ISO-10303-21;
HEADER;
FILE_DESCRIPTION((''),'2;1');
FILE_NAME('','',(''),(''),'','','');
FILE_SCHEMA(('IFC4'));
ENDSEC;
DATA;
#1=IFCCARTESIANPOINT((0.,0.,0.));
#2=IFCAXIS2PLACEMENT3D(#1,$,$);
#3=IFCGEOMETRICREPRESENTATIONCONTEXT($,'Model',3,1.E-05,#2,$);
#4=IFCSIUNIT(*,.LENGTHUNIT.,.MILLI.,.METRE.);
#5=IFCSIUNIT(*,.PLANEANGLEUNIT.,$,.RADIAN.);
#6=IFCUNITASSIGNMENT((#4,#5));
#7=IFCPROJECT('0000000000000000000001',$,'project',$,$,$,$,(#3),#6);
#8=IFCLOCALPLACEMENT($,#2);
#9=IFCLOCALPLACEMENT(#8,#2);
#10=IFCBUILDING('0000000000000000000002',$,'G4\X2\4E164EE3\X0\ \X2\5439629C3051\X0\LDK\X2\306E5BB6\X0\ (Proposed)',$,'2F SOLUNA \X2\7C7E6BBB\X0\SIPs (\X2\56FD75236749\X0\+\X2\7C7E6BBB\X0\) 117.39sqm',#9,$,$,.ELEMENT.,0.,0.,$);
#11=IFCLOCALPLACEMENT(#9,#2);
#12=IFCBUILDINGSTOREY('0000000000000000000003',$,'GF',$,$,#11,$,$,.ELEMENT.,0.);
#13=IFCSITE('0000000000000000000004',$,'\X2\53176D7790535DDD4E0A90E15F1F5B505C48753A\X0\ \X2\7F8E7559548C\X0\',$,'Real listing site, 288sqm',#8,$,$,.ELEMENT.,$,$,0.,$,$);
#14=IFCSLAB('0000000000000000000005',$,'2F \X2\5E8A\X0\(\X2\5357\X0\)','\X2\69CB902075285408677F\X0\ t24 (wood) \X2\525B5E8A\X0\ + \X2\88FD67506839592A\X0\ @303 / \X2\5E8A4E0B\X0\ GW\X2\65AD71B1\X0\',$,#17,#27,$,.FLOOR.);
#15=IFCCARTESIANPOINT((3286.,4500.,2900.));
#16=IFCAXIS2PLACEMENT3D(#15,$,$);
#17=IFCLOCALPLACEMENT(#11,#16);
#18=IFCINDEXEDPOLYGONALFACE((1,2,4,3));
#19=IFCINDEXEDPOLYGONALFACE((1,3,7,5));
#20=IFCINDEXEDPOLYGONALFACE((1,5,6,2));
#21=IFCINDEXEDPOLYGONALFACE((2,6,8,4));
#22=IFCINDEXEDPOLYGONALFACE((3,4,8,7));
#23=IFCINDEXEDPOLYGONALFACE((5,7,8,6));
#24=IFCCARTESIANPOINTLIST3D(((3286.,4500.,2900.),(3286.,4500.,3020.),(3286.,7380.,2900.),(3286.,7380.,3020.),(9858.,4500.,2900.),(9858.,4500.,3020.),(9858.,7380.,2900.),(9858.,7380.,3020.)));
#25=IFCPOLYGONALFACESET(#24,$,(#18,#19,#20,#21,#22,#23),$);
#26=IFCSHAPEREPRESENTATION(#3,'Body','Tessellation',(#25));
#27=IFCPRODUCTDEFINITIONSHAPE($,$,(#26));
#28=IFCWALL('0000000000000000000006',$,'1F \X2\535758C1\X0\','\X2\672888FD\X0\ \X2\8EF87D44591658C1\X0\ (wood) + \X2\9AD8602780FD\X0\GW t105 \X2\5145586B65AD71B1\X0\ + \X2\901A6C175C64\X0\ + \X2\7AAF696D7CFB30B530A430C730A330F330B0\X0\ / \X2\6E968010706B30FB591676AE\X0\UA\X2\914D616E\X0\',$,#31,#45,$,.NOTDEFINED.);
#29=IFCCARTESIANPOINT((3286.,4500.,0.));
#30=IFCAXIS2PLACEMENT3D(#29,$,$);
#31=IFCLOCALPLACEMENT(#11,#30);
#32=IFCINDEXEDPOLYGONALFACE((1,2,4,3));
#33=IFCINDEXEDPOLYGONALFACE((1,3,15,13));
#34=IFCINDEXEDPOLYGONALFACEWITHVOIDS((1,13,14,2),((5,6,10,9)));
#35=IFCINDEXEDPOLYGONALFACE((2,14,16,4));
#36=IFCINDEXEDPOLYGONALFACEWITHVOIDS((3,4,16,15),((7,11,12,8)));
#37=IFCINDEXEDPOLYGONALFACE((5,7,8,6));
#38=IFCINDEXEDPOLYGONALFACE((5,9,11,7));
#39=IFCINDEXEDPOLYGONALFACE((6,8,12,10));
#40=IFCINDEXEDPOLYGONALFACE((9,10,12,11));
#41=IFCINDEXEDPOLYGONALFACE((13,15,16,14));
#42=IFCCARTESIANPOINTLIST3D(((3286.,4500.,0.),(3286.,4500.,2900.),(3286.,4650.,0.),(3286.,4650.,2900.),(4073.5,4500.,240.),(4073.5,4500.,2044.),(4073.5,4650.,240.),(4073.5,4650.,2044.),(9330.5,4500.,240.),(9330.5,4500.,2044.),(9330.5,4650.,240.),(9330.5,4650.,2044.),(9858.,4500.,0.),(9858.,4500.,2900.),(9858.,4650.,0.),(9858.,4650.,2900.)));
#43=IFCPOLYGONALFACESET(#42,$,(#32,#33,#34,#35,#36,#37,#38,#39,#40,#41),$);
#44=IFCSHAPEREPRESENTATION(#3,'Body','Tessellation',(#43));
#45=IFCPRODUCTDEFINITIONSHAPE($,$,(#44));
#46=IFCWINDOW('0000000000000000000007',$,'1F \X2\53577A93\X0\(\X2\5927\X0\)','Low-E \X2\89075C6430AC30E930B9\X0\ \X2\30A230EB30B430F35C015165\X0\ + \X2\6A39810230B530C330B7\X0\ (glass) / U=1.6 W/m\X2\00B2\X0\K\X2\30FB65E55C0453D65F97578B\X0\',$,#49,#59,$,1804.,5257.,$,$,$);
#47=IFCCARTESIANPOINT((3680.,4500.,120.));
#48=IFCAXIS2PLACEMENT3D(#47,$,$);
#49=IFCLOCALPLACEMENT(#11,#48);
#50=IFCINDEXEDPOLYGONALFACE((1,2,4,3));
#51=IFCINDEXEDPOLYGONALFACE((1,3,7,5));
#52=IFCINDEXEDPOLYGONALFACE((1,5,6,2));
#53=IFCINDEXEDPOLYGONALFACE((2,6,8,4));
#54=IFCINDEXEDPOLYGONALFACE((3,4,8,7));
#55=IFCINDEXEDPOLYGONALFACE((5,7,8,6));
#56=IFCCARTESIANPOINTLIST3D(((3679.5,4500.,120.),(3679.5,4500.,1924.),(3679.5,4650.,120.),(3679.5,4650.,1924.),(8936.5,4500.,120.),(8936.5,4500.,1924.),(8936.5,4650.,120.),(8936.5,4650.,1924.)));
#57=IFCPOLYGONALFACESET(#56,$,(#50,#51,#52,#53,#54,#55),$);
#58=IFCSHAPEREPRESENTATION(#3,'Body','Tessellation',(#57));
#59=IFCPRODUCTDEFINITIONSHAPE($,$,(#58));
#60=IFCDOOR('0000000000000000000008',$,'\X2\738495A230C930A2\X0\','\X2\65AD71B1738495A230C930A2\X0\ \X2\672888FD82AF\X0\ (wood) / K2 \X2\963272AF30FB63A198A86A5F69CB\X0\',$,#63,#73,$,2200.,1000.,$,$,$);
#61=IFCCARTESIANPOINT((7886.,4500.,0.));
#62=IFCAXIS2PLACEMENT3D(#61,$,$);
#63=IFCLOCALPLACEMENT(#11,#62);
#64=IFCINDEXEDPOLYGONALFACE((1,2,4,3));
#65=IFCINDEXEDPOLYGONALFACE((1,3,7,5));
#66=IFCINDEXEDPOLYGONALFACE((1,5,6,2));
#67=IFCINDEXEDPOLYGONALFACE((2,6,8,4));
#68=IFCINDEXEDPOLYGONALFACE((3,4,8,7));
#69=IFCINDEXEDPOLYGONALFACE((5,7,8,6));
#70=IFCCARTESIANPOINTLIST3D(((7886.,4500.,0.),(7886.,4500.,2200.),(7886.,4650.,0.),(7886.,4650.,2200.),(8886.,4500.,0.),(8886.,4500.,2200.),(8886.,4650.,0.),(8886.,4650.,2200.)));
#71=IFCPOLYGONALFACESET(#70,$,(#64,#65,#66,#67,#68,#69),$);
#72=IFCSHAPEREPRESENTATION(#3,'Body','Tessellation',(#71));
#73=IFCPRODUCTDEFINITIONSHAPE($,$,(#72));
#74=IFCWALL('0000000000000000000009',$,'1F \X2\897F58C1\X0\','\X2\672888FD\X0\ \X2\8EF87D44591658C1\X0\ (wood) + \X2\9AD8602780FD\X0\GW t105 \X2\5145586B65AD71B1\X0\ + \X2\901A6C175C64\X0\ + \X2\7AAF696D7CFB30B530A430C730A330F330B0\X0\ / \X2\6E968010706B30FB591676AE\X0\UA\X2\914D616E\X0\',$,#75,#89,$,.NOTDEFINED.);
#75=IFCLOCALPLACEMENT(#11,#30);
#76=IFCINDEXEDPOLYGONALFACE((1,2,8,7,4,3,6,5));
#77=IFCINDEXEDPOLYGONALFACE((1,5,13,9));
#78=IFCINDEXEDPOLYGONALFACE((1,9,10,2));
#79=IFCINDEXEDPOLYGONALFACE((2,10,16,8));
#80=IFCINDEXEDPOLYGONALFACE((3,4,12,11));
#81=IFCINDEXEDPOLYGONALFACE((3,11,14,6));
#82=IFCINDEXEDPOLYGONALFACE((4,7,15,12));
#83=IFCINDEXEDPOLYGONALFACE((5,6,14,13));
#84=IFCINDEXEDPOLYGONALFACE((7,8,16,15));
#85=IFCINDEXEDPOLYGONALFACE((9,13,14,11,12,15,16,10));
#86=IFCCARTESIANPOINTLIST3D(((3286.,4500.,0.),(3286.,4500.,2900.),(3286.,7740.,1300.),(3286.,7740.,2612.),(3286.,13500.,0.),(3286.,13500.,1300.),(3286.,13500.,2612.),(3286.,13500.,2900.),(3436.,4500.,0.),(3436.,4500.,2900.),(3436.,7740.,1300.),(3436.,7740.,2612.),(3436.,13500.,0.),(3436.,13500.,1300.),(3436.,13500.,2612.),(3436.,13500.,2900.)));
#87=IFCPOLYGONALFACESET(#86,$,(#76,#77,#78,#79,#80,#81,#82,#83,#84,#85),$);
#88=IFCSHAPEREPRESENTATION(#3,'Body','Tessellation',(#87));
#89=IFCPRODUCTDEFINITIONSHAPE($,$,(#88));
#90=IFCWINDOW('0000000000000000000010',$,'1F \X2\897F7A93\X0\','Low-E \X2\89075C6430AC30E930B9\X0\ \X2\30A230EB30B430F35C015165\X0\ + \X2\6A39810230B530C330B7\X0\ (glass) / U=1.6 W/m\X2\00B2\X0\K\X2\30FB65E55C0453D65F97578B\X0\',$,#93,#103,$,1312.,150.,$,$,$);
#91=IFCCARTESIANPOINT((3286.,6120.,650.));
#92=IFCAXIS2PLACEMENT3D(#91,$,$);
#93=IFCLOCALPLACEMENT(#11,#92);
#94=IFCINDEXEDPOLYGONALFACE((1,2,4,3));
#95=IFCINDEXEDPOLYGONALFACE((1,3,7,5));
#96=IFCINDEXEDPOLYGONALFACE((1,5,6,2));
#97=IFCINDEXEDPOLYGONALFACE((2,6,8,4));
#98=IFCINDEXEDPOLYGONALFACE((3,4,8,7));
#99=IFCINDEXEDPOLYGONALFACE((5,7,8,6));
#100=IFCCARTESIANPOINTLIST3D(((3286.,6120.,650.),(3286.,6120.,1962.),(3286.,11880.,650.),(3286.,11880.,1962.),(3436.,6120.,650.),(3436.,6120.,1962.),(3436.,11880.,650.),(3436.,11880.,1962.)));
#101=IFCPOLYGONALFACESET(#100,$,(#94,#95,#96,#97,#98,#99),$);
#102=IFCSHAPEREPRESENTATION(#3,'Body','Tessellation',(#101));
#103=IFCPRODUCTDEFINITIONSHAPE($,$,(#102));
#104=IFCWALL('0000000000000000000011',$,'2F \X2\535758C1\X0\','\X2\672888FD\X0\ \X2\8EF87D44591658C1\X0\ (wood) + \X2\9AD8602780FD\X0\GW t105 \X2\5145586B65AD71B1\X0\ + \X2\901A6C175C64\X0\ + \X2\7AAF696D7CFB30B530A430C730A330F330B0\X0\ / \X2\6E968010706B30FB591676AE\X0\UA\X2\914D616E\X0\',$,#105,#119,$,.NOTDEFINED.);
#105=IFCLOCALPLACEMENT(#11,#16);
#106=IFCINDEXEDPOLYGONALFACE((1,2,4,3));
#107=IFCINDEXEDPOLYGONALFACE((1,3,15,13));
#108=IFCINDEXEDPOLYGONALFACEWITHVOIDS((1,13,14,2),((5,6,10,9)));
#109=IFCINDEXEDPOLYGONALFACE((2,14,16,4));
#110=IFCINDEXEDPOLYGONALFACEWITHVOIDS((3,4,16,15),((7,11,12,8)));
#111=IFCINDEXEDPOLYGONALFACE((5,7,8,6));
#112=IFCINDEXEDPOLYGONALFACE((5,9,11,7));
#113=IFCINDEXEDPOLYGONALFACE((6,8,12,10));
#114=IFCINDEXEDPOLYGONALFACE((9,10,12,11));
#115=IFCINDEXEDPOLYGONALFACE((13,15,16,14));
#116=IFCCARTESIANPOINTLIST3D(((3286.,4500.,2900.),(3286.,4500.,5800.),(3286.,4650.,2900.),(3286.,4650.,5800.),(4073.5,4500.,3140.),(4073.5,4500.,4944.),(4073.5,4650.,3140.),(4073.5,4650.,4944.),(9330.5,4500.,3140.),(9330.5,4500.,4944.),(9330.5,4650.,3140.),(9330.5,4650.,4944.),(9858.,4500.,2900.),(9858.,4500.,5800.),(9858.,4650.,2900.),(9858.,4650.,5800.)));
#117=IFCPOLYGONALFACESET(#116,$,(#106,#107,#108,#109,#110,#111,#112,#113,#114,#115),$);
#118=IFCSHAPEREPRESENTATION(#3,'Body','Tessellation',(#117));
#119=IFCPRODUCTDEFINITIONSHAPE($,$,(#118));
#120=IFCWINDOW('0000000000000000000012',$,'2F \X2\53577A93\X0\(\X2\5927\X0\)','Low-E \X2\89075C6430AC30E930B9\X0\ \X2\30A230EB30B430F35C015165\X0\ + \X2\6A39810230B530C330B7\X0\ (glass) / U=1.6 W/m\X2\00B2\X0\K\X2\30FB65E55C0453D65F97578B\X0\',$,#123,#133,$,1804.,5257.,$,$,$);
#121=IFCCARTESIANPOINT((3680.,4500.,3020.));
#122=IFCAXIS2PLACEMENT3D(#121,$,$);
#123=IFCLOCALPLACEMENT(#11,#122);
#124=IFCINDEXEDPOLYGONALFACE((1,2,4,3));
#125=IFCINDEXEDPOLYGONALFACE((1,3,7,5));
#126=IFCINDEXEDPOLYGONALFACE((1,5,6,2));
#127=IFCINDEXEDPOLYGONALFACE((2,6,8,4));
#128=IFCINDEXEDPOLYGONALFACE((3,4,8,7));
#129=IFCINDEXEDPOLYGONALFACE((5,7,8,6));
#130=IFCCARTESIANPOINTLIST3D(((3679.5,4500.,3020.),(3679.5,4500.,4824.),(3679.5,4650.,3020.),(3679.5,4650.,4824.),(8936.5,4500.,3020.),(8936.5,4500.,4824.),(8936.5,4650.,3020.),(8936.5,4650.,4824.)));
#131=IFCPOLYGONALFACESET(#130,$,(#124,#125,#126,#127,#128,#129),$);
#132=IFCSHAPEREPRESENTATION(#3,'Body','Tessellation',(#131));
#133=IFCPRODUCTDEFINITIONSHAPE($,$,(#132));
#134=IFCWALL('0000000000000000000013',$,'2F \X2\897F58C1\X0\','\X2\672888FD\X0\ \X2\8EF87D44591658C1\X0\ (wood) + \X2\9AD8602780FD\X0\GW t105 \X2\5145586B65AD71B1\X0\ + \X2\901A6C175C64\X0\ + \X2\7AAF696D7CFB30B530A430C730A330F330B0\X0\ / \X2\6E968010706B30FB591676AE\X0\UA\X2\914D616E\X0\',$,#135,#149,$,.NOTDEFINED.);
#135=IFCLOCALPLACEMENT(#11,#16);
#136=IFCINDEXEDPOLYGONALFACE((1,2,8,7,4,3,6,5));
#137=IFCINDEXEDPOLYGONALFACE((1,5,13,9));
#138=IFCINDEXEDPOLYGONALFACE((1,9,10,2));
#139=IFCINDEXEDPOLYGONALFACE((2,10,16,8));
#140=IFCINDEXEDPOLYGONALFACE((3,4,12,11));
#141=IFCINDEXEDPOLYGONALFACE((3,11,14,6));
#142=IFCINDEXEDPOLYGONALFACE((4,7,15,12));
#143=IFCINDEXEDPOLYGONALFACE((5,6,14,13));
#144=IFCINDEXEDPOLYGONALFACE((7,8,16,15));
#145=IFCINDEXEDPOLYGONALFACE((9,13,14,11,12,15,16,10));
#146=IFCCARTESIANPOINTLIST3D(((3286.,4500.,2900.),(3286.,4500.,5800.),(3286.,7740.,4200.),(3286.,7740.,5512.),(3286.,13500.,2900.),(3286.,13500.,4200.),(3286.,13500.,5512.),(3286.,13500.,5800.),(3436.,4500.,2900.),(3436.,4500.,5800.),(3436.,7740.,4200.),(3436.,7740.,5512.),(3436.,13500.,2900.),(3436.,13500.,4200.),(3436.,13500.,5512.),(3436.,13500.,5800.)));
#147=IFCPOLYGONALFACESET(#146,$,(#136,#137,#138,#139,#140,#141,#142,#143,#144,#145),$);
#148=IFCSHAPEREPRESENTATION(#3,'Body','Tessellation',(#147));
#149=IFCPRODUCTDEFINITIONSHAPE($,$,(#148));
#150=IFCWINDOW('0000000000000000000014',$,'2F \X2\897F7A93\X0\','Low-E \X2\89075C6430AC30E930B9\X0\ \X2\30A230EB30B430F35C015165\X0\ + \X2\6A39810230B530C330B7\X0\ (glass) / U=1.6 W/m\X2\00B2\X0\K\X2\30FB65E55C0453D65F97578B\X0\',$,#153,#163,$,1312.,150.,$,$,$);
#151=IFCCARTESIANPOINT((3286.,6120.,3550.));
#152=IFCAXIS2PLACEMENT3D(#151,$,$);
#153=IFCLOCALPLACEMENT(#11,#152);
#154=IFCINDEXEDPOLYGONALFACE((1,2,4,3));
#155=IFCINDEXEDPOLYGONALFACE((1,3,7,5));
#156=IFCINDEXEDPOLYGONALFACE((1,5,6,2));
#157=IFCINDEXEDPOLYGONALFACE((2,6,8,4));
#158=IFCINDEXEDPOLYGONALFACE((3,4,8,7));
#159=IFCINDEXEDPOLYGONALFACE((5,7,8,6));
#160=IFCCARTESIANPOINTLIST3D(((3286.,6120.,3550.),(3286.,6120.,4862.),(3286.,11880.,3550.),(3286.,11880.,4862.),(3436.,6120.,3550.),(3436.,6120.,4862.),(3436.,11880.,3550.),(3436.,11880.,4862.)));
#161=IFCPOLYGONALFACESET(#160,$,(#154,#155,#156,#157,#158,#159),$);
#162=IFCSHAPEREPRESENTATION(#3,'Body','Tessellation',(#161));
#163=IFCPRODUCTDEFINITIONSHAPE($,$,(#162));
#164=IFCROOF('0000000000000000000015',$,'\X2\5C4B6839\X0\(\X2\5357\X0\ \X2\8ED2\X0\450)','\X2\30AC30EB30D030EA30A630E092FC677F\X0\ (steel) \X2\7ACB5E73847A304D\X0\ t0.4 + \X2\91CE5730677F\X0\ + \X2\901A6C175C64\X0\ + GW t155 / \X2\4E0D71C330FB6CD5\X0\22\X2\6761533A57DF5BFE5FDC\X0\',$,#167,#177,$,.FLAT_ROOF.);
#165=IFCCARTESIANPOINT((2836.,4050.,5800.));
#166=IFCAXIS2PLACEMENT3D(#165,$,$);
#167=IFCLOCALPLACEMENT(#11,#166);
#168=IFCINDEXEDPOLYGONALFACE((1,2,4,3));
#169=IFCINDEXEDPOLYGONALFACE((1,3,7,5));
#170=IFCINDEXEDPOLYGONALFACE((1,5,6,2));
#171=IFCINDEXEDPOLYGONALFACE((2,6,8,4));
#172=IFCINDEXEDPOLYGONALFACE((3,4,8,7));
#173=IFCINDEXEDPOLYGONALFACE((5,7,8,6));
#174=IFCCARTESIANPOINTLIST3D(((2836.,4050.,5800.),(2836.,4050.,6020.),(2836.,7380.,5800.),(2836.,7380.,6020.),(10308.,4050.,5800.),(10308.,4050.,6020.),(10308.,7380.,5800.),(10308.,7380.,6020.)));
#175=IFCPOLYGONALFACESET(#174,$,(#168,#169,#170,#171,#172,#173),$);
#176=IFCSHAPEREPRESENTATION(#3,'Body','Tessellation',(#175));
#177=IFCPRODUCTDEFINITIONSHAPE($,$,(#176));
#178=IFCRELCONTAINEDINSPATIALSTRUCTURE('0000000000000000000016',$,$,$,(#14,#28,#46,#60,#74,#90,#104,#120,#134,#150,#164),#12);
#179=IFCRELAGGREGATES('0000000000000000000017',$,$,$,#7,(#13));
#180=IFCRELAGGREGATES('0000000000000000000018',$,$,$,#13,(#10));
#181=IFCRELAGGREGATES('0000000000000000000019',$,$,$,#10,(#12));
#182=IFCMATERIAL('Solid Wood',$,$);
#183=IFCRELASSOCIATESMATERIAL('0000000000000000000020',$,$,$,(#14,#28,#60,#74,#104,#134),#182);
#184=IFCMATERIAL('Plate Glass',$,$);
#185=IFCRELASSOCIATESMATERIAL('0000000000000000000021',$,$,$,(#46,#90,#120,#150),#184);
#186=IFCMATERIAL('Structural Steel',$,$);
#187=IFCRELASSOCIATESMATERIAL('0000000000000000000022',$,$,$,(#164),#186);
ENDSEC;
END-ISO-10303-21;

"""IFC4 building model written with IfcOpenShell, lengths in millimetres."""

from ifc_helpers import new_model, si_unit, frame, frame_2d, origin, place, context, project, spatial, rectangle, extrude, material, element, fill, save


model = new_model("IFC4")

# Units and contexts
model_context = context("Model", 3, precision=1e-05, world=origin())
ifc_project = project(units=[si_unit("LENGTHUNIT", "METRE", prefix="MILLI"), si_unit("PLANEANGLEUNIT", "RADIAN")], contexts=[model_context])

# Site, building, storey
site_placement = place(None, origin())
site = spatial("IfcSite", under=ifc_project, at=site_placement, Name="北海道川上郡弟子屈町 美留和", ObjectType="Real listing site, 288sqm", CompositionType="ELEMENT", RefElevation=0.0)
building_placement = place(site_placement, origin())
building = spatial("IfcBuilding", under=site, at=building_placement, Name="G4世代 吹抜けLDKの家 (Proposed)", ObjectType="2F SOLUNA 籾殻SIPs (国産杉+籾殻) 117.39sqm", CompositionType="ELEMENT", ElevationOfRefHeight=0.0, ElevationOfTerrain=0.0)
storey_placement = place(building_placement, origin())
storey = spatial("IfcBuildingStorey", under=building, at=storey_placement, Name="GF", CompositionType="ELEMENT", Elevation=0.0)

# Slab
ifc_material_1 = material(Name="Solid Wood")
slab_1_placement = place(storey_placement, frame((3286.0, 4500.0, 2900.0)))
element("IfcSlab", 1, at=slab_1_placement, inside=storey, material=ifc_material_1, Name="2F 床(南)", Description="構造用合板 t24 (wood) 剛床 + 製材根太 @303 / 床下 GW断熱", PredefinedType="FLOOR", context=model_context, shape_type="SweptSolid", body=[
    extrude(rectangle(XDim=6572.0, YDim=2880.0, at=frame_2d((3286.0, 1440.0))), frame((3286.0, 4500.0, 2900.0)), (0.0, 0.0, 1.0), 120.0),
])

# Wall, openings, window, door
wall_1_placement = place(storey_placement, frame((3286.0, 4500.0, 0.0)))
wall_1 = element("IfcWall", 2, at=wall_1_placement, inside=storey, material=ifc_material_1, Name="1F 南壁", Description="木製 軸組外壁 (wood) + 高性能GW t105 充填断熱 + 通気層 + 窯業系サイディング / 準耐火・外皮UA配慮", PredefinedType="NOTDEFINED", context=model_context, shape_type="SweptSolid", body=[
    extrude(rectangle(XDim=6572.0, YDim=150.0, at=frame_2d((3286.0, 75.0))), frame((3286.0, 4500.0, 0.0)), (0.0, 0.0, 1.0), 2900.0),
])
opening_1_placement = place(storey_placement, frame((3680.0, 4500.0, 120.0)))
opening_1 = element("IfcOpeningElement", 3, at=opening_1_placement, cuts=wall_1, PredefinedType="NOTDEFINED", context=model_context, shape_type="SweptSolid", body=[
    extrude(rectangle(XDim=5257.0, YDim=150.0, at=frame_2d((2628.0, 75.0))), frame((3680.0, 4500.0, 120.0)), (0.0, 0.0, 1.0), 1804.0),
])
opening_2_placement = place(storey_placement, frame((7886.0, 4500.0, 0.0)))
opening_2 = element("IfcOpeningElement", 4, at=opening_2_placement, cuts=wall_1, PredefinedType="NOTDEFINED", context=model_context, shape_type="SweptSolid", body=[
    extrude(rectangle(XDim=1000.0, YDim=150.0, at=frame_2d((500.0, 75.0))), frame((7886.0, 4500.0, 0.0)), (0.0, 0.0, 1.0), 2200.0),
])
ifc_material_2 = material(Name="Plate Glass")
window_1_placement = place(storey_placement, frame((3680.0, 4500.0, 120.0)))
window_1 = element("IfcWindow", 5, at=window_1_placement, inside=storey, material=ifc_material_2, Name="1F 南窓(大)", Description="Low-E 複層ガラス アルゴン封入 + 樹脂サッシ (glass) / U=1.6 W/m²K・日射取得型", OverallHeight=1804.0, OverallWidth=5257.0, context=model_context, shape_type="SweptSolid", body=[
    extrude(rectangle(XDim=5257.0, YDim=150.0, at=frame_2d((2628.0, 75.0))), frame((3680.0, 4500.0, 120.0)), (0.0, 0.0, 1.0), 1804.0),
])
fill(opening_1, window_1)
door_placement = place(storey_placement, frame((7886.0, 4500.0, 0.0)))
door = element("IfcDoor", 6, at=door_placement, inside=storey, material=ifc_material_1, Name="玄関ドア", Description="断熱玄関ドア 木製芯 (wood) / K2 防犯・採風機構", OverallHeight=2200.0, OverallWidth=1000.0, context=model_context, shape_type="SweptSolid", body=[
    extrude(rectangle(XDim=1000.0, YDim=150.0, at=frame_2d((500.0, 75.0))), frame((7886.0, 4500.0, 0.0)), (0.0, 0.0, 1.0), 2200.0),
])
fill(opening_2, door)

# Walls, openings, windows
wall_2_placement = place(storey_placement, frame((3286.0, 4500.0, 0.0)))
wall_2 = element("IfcWall", 7, at=wall_2_placement, inside=storey, material=ifc_material_1, Name="1F 西壁", Description="木製 軸組外壁 (wood) + 高性能GW t105 充填断熱 + 通気層 + 窯業系サイディング / 準耐火・外皮UA配慮", PredefinedType="NOTDEFINED", context=model_context, shape_type="SweptSolid", body=[
    extrude(rectangle(XDim=150.0, YDim=9000.0, at=frame_2d((75.0, 4500.0))), frame((3286.0, 4500.0, 0.0)), (0.0, 0.0, 1.0), 2900.0),
])
opening_3_placement = place(storey_placement, frame((3286.0, 6120.0, 650.0)))
opening_3 = element("IfcOpeningElement", 8, at=opening_3_placement, cuts=wall_2, PredefinedType="NOTDEFINED", context=model_context, shape_type="SweptSolid", body=[
    extrude(rectangle(XDim=150.0, YDim=5760.0, at=frame_2d((75.0, 2880.0))), frame((3286.0, 6120.0, 650.0)), (0.0, 0.0, 1.0), 1312.0),
])
window_2_placement = place(storey_placement, frame((3286.0, 6120.0, 650.0)))
window_2 = element("IfcWindow", 9, at=window_2_placement, inside=storey, material=ifc_material_2, Name="1F 西窓", Description="Low-E 複層ガラス アルゴン封入 + 樹脂サッシ (glass) / U=1.6 W/m²K・日射取得型", OverallHeight=1312.0, OverallWidth=150.0, context=model_context, shape_type="SweptSolid", body=[
    extrude(rectangle(XDim=150.0, YDim=5760.0, at=frame_2d((75.0, 2880.0))), frame((3286.0, 6120.0, 650.0)), (0.0, 0.0, 1.0), 1312.0),
])
fill(opening_3, window_2)
wall_3_placement = place(storey_placement, frame((3286.0, 4500.0, 2900.0)))
wall_3 = element("IfcWall", 10, at=wall_3_placement, inside=storey, material=ifc_material_1, Name="2F 南壁", Description="木製 軸組外壁 (wood) + 高性能GW t105 充填断熱 + 通気層 + 窯業系サイディング / 準耐火・外皮UA配慮", PredefinedType="NOTDEFINED", context=model_context, shape_type="SweptSolid", body=[
    extrude(rectangle(XDim=6572.0, YDim=150.0, at=frame_2d((3286.0, 75.0))), frame((3286.0, 4500.0, 2900.0)), (0.0, 0.0, 1.0), 2900.0),
])
opening_4_placement = place(storey_placement, frame((3680.0, 4500.0, 3020.0)))
opening_4 = element("IfcOpeningElement", 11, at=opening_4_placement, cuts=wall_3, PredefinedType="NOTDEFINED", context=model_context, shape_type="SweptSolid", body=[
    extrude(rectangle(XDim=5257.0, YDim=150.0, at=frame_2d((2628.0, 75.0))), frame((3680.0, 4500.0, 3020.0)), (0.0, 0.0, 1.0), 1804.0),
])
window_3_placement = place(storey_placement, frame((3680.0, 4500.0, 3020.0)))
window_3 = element("IfcWindow", 12, at=window_3_placement, inside=storey, material=ifc_material_2, Name="2F 南窓(大)", Description="Low-E 複層ガラス アルゴン封入 + 樹脂サッシ (glass) / U=1.6 W/m²K・日射取得型", OverallHeight=1804.0, OverallWidth=5257.0, context=model_context, shape_type="SweptSolid", body=[
    extrude(rectangle(XDim=5257.0, YDim=150.0, at=frame_2d((2628.0, 75.0))), frame((3680.0, 4500.0, 3020.0)), (0.0, 0.0, 1.0), 1804.0),
])
fill(opening_4, window_3)
wall_4_placement = place(storey_placement, frame((3286.0, 4500.0, 2900.0)))
wall_4 = element("IfcWall", 13, at=wall_4_placement, inside=storey, material=ifc_material_1, Name="2F 西壁", Description="木製 軸組外壁 (wood) + 高性能GW t105 充填断熱 + 通気層 + 窯業系サイディング / 準耐火・外皮UA配慮", PredefinedType="NOTDEFINED", context=model_context, shape_type="SweptSolid", body=[
    extrude(rectangle(XDim=150.0, YDim=9000.0, at=frame_2d((75.0, 4500.0))), frame((3286.0, 4500.0, 2900.0)), (0.0, 0.0, 1.0), 2900.0),
])
opening_5_placement = place(storey_placement, frame((3286.0, 6120.0, 3550.0)))
opening_5 = element("IfcOpeningElement", 14, at=opening_5_placement, cuts=wall_4, PredefinedType="NOTDEFINED", context=model_context, shape_type="SweptSolid", body=[
    extrude(rectangle(XDim=150.0, YDim=5760.0, at=frame_2d((75.0, 2880.0))), frame((3286.0, 6120.0, 3550.0)), (0.0, 0.0, 1.0), 1312.0),
])
window_4_placement = place(storey_placement, frame((3286.0, 6120.0, 3550.0)))
window_4 = element("IfcWindow", 15, at=window_4_placement, inside=storey, material=ifc_material_2, Name="2F 西窓", Description="Low-E 複層ガラス アルゴン封入 + 樹脂サッシ (glass) / U=1.6 W/m²K・日射取得型", OverallHeight=1312.0, OverallWidth=150.0, context=model_context, shape_type="SweptSolid", body=[
    extrude(rectangle(XDim=150.0, YDim=5760.0, at=frame_2d((75.0, 2880.0))), frame((3286.0, 6120.0, 3550.0)), (0.0, 0.0, 1.0), 1312.0),
])
fill(opening_5, window_4)

# Roof
ifc_material_3 = material(Name="Structural Steel")
roof_1_placement = place(storey_placement, frame((2836.0, 4050.0, 5800.0)))
element("IfcRoof", 16, at=roof_1_placement, inside=storey, material=ifc_material_3, Name="屋根(南 軒450)", Description="ガルバリウム鋼板 (steel) 立平葺き t0.4 + 野地板 + 通気層 + GW t155 / 不燃・法22条区域対応", PredefinedType="FLAT_ROOF", context=model_context, shape_type="SweptSolid", body=[
    extrude(rectangle(XDim=7472.0, YDim=3330.0, at=frame_2d((3736.0, 1665.0))), frame((2836.0, 4050.0, 5800.0)), (0.0, 0.0, 1.0), 220.0),
])

save(model, "model.ifc")
